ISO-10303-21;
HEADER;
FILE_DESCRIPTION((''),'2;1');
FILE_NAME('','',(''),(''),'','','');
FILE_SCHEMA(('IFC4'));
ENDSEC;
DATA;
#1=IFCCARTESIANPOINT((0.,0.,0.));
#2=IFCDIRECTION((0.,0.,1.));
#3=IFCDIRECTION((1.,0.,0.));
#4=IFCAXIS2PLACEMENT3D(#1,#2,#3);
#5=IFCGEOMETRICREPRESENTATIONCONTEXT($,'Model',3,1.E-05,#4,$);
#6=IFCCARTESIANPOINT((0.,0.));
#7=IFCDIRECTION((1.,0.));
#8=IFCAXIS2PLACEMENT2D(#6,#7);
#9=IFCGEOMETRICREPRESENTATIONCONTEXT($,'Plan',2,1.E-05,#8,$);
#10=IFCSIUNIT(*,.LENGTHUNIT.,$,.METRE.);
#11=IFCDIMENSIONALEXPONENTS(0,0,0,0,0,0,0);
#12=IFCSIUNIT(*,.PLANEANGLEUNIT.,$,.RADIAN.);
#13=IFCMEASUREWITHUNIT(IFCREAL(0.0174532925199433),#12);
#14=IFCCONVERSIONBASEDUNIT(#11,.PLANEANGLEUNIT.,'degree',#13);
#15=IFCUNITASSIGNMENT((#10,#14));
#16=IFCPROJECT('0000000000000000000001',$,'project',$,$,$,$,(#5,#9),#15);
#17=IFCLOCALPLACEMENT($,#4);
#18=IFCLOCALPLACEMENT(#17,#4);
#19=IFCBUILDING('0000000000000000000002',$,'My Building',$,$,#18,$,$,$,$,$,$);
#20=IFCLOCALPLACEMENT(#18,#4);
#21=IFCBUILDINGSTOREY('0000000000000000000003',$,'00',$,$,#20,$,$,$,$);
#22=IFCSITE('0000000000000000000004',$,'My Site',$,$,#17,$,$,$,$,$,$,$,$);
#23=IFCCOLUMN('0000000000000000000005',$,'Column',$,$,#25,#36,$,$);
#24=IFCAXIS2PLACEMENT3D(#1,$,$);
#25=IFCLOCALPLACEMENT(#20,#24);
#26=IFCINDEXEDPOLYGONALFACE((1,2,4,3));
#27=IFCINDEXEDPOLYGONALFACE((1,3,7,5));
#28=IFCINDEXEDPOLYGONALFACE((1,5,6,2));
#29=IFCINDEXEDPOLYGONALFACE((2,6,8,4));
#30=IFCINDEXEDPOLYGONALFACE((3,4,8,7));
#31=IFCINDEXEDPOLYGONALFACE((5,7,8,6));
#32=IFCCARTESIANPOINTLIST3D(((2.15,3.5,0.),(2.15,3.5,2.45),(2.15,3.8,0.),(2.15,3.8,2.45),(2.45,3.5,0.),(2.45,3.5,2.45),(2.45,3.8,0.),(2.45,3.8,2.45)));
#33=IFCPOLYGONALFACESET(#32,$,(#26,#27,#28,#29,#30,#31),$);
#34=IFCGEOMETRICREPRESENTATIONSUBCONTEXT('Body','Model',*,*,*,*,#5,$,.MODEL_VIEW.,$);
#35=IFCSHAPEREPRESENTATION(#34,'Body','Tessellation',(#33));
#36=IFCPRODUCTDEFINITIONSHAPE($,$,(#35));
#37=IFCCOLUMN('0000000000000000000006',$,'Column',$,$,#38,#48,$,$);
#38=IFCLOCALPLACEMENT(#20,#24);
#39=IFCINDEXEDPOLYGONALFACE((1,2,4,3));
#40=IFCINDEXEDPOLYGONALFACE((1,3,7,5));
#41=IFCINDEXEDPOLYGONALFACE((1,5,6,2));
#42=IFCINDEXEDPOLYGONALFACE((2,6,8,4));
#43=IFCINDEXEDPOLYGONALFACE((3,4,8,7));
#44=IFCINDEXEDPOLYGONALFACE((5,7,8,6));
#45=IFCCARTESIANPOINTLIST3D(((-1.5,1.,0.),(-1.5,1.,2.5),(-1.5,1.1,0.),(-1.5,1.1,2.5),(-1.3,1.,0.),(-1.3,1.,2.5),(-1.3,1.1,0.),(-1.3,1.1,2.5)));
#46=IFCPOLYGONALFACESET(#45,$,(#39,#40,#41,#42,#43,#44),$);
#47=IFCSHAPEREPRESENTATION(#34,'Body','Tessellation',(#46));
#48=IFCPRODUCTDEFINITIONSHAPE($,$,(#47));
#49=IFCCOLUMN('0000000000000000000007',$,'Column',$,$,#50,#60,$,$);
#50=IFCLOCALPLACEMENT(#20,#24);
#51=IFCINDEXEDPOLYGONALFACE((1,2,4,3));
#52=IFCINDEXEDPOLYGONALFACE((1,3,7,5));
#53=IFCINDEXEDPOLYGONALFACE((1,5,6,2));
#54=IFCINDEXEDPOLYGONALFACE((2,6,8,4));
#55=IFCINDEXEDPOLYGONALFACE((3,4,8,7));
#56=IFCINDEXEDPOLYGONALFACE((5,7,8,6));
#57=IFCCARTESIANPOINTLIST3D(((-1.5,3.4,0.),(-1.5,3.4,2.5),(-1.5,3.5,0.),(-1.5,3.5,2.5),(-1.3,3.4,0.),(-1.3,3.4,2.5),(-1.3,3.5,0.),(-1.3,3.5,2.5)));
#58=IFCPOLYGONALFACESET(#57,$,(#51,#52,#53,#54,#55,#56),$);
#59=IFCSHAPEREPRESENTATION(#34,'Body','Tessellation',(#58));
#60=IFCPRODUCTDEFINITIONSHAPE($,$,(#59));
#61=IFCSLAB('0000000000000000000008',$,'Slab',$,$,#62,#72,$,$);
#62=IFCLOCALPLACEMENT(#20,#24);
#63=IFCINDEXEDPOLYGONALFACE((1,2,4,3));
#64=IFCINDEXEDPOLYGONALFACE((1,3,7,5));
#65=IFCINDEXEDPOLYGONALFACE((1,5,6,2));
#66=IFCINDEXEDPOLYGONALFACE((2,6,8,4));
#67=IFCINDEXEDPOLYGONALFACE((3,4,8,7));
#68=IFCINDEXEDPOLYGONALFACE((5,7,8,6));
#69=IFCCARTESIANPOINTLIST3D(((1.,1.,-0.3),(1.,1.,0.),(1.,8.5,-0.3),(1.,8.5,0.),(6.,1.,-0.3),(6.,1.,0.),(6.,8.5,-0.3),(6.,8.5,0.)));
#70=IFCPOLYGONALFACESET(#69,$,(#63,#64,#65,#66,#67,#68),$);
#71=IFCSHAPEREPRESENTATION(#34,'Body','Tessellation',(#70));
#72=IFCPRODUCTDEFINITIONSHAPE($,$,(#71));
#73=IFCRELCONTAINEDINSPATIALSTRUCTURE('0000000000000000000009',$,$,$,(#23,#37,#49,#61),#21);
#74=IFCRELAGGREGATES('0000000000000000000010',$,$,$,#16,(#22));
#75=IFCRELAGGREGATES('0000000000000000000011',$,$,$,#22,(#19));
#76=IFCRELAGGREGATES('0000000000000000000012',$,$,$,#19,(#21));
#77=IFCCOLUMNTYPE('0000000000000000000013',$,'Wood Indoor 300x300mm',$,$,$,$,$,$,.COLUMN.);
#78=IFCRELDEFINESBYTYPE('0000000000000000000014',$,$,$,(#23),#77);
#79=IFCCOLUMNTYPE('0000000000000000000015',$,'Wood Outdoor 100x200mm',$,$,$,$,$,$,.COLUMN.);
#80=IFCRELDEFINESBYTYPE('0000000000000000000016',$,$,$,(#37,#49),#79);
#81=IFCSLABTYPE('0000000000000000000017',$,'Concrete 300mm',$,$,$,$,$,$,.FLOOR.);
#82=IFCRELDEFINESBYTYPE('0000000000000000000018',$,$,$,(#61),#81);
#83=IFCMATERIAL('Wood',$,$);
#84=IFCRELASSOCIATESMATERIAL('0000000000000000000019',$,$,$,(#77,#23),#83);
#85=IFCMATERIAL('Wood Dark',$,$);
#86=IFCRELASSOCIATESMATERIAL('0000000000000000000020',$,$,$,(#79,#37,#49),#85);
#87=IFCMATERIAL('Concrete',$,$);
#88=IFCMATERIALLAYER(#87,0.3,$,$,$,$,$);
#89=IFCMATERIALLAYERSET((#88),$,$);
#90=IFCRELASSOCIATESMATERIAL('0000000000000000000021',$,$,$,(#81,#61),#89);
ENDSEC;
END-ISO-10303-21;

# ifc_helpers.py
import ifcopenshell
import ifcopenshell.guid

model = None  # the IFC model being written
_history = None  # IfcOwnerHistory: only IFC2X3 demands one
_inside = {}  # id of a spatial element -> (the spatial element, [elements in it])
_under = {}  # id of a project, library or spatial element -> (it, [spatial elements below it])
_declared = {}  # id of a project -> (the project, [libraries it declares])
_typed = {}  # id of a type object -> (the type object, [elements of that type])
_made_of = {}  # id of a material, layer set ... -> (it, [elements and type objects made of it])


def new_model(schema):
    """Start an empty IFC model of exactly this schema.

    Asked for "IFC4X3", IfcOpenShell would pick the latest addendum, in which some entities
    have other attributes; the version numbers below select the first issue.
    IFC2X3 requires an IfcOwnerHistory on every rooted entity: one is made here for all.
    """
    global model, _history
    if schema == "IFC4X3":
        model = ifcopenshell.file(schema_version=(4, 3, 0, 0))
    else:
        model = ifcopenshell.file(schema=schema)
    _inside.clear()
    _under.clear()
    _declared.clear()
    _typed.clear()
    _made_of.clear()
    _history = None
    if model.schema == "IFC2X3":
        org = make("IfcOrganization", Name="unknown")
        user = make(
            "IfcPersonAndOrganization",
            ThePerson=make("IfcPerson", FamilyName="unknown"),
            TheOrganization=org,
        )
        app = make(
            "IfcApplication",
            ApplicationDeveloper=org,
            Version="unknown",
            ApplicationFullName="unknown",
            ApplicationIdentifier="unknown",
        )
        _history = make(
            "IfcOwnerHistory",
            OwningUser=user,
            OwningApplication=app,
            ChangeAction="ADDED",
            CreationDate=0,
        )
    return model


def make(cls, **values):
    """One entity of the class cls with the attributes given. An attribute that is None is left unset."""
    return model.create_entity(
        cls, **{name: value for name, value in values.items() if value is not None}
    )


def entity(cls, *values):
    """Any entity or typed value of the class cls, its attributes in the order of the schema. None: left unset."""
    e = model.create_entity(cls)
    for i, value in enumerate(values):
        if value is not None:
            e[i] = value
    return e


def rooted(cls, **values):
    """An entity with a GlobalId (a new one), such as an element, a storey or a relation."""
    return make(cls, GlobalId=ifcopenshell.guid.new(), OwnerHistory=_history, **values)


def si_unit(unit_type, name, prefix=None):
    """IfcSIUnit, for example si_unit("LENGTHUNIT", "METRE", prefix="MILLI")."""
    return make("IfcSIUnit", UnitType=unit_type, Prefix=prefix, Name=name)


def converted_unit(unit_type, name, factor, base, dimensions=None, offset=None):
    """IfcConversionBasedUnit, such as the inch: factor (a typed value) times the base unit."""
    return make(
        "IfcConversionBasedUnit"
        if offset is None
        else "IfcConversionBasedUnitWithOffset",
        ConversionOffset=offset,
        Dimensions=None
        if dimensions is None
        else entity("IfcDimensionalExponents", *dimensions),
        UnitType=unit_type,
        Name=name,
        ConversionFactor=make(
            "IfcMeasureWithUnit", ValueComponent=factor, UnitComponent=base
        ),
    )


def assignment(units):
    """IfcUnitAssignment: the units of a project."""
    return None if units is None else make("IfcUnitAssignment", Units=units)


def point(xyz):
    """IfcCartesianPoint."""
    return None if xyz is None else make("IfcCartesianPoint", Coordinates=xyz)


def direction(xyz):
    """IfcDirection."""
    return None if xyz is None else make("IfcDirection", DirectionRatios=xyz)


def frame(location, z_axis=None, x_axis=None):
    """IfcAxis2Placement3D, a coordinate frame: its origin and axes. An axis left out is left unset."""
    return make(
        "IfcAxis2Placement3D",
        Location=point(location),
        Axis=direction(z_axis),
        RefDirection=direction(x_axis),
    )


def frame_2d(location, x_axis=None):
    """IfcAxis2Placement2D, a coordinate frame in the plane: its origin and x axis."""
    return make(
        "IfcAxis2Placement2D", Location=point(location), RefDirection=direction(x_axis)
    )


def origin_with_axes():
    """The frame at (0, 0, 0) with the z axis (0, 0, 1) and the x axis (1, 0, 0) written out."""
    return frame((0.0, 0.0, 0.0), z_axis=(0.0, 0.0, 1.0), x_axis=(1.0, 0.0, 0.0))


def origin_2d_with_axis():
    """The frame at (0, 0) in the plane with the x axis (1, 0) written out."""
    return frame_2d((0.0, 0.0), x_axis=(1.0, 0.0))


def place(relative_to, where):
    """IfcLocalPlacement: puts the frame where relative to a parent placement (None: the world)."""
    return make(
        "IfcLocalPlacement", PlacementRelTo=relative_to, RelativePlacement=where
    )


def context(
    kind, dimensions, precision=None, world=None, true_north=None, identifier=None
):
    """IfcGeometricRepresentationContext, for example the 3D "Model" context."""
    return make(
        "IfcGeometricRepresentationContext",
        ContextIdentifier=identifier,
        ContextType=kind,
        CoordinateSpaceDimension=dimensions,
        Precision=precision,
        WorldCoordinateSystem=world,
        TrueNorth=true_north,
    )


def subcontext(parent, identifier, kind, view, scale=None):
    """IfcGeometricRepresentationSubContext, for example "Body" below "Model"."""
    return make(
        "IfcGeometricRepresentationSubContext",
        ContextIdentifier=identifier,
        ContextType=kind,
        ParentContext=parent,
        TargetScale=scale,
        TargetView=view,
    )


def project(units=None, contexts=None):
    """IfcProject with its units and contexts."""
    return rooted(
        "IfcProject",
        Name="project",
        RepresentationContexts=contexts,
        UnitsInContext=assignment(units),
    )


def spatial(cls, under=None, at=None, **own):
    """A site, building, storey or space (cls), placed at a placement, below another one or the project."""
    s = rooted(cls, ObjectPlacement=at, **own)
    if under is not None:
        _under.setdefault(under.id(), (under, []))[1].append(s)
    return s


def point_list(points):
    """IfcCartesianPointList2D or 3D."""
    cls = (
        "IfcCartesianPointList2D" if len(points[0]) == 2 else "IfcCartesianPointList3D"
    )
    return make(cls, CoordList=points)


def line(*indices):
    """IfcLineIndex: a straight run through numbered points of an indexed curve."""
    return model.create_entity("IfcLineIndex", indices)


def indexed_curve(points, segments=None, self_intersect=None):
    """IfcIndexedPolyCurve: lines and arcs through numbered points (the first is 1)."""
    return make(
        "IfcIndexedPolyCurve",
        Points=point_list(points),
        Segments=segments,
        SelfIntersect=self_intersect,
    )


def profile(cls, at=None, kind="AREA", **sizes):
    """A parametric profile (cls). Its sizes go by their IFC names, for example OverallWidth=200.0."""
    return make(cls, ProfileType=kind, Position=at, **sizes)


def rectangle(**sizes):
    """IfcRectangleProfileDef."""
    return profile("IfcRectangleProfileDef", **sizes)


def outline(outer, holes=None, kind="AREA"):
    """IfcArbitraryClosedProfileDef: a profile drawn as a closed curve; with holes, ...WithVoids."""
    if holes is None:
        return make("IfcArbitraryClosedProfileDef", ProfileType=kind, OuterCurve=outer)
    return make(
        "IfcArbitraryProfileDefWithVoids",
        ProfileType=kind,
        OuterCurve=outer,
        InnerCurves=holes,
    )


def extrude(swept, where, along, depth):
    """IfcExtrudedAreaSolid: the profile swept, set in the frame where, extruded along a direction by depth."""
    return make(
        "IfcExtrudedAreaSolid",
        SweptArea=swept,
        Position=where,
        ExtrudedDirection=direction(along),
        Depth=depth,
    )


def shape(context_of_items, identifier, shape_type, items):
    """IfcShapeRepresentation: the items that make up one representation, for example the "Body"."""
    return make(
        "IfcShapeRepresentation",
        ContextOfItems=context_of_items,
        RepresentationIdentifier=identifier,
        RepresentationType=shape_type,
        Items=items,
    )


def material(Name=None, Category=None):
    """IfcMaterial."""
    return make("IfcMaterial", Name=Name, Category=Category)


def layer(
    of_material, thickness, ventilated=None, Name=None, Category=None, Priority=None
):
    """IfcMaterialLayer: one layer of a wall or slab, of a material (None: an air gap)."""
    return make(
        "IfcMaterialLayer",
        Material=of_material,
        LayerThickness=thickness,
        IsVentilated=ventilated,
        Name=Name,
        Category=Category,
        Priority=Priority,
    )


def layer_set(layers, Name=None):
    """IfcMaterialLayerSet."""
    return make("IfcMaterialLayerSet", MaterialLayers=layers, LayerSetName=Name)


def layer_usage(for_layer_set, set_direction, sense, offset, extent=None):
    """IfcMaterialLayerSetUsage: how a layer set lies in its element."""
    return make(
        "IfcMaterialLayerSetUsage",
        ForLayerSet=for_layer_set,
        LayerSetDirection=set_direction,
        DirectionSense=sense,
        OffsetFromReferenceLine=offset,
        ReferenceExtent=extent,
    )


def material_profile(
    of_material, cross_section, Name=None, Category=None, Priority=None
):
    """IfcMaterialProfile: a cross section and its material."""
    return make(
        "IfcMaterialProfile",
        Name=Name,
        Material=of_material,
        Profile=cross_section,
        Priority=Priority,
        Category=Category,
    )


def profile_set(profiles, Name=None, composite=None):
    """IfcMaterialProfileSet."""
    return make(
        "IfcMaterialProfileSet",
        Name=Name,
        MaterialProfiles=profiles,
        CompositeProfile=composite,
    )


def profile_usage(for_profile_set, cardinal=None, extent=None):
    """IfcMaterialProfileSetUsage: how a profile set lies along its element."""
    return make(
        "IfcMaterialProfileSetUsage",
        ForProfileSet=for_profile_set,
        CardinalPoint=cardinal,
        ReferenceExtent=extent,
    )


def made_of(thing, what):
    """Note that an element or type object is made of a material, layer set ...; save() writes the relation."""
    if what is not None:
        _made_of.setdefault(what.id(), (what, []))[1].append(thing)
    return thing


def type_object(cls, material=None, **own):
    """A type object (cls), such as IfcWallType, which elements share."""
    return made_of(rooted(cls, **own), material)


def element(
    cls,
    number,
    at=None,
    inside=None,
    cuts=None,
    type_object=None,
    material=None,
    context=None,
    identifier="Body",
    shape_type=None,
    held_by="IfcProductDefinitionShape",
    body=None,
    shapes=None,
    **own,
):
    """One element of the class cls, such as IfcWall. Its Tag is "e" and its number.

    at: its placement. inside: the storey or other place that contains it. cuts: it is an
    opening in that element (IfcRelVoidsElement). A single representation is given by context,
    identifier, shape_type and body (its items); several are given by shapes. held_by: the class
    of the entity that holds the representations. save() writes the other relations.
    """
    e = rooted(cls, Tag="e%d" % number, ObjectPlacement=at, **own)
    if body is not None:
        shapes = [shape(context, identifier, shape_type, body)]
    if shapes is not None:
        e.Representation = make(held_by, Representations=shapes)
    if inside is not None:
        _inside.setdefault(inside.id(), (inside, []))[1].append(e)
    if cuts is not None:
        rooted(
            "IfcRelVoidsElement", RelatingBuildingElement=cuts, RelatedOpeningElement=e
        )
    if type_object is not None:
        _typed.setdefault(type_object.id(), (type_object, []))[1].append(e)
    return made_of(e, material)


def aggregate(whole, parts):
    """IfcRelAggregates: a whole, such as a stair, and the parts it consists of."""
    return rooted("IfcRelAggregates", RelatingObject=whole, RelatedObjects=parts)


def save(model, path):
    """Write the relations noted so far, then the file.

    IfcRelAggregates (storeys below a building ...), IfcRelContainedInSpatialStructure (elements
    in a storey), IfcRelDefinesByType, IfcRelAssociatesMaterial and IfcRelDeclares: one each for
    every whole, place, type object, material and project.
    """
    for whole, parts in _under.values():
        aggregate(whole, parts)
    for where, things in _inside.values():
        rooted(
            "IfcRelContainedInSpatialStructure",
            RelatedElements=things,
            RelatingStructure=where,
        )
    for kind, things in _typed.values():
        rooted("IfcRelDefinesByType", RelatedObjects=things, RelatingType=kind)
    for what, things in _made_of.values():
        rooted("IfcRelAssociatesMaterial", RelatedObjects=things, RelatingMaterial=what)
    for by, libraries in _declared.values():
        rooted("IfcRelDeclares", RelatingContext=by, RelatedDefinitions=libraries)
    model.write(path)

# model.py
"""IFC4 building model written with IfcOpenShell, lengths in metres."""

from ifc_helpers import new_model, entity, si_unit, converted_unit, frame, origin_with_axes, origin_2d_with_axis, place, context, subcontext, project, spatial, line, indexed_curve, rectangle, outline, extrude, material, layer, layer_set, layer_usage, material_profile, profile_set, profile_usage, type_object, element, save


model = new_model("IFC4")

# Units and contexts
model_context = context("Model", 3, precision=1e-05, world=origin_with_axes())
plan_context = context("Plan", 2, precision=1e-05, world=origin_2d_with_axis())
body_context_1 = subcontext(model_context, "Body", "Model", "MODEL_VIEW")
ifc_project = project(units=[si_unit("LENGTHUNIT", "METRE"), converted_unit("PLANEANGLEUNIT", "degree", entity("IfcReal", 0.0174532925199433), si_unit("PLANEANGLEUNIT", "RADIAN"), dimensions=[0, 0, 0, 0, 0, 0, 0])], contexts=[model_context, plan_context])

# Site, building, storey
site_placement = place(None, origin_with_axes())
site = spatial("IfcSite", under=ifc_project, at=site_placement, Name="My Site")
building_placement = place(site_placement, origin_with_axes())
building = spatial("IfcBuilding", under=site, at=building_placement, Name="My Building")
storey_placement = place(building_placement, origin_with_axes())
storey = spatial("IfcBuildingStorey", under=building, at=storey_placement, Name="00")

# Columns
ifc_material_1 = material(Name="Wood")
ifc_material_profile_1 = material_profile(ifc_material_1, rectangle(XDim=0.3, YDim=0.3))
ifc_profile_set_1 = profile_set([ifc_material_profile_1])
ifc_profile_usage_1 = profile_usage(ifc_profile_set_1, cardinal=3)
column_type_1 = type_object("IfcColumnType", Name="Wood Indoor 300x300mm", PredefinedType="COLUMN", material=ifc_profile_set_1)
column_1_placement = place(storey_placement, frame((2.15, 3.5, 0.0), z_axis=(0.0, 0.0, 1.0), x_axis=(1.0, 0.0, 0.0)))
element("IfcColumn", 1, at=column_1_placement, inside=storey, type_object=column_type_1, material=ifc_profile_usage_1, Name="Column", context=body_context_1, shape_type="SweptSolid", body=[
    extrude(rectangle(XDim=0.3, YDim=0.3), frame((0.15, 0.15, 0.0), z_axis=(0.0, 0.0, 1.0), x_axis=(1.0, 0.0, 0.0)), (0.0, 0.0, 1.0), 2.45),
])
ifc_material_2 = material(Name="Wood Dark")
ifc_material_profile_2 = material_profile(ifc_material_2, rectangle(XDim=0.1, YDim=0.2, kind="CURVE"))
ifc_profile_set_2 = profile_set([ifc_material_profile_2])
ifc_profile_usage_2 = profile_usage(ifc_profile_set_2, cardinal=1)
column_type_2 = type_object("IfcColumnType", Name="Wood Outdoor 100x200mm", PredefinedType="COLUMN", material=ifc_profile_set_2)
column_2_placement = place(storey_placement, frame((-1.5, 1.0, 0.0), z_axis=(0.0, 0.0, 1.0), x_axis=(0.0, -1.0, 0.0)))
element("IfcColumn", 2, at=column_2_placement, inside=storey, type_object=column_type_2, material=ifc_profile_usage_2, Name="Column", context=body_context_1, shape_type="SweptSolid", body=[
    extrude(rectangle(XDim=0.1, YDim=0.2, kind="CURVE"), frame((-0.05, 0.1, 0.0), z_axis=(0.0, 0.0, 1.0), x_axis=(1.0, 0.0, 0.0)), (0.0, 0.0, 1.0), 2.5),
])
ifc_profile_usage_3 = profile_usage(ifc_profile_set_2, cardinal=3)
column_3_placement = place(storey_placement, frame((-1.5, 3.5, 0.0), z_axis=(0.0, 0.0, 1.0), x_axis=(0.0, -1.0, 0.0)))
element("IfcColumn", 3, at=column_3_placement, inside=storey, type_object=column_type_2, material=ifc_profile_usage_3, Name="Column", context=body_context_1, shape_type="SweptSolid", body=[
    extrude(rectangle(XDim=0.1, YDim=0.2, kind="CURVE"), frame((0.05, 0.1, 0.0), z_axis=(0.0, 0.0, 1.0), x_axis=(1.0, 0.0, 0.0)), (0.0, 0.0, 1.0), 2.5),
])

# Slab
ifc_material_3 = material(Name="Concrete")
ifc_layer_1 = layer(ifc_material_3, 0.3)
ifc_layer_set_1 = layer_set([ifc_layer_1])
ifc_layer_usage_1 = layer_usage(ifc_layer_set_1, "AXIS3", "POSITIVE", 0.0)
slab_type = type_object("IfcSlabType", Name="Concrete 300mm", PredefinedType="FLOOR", material=ifc_layer_set_1)
slab_placement = place(storey_placement, frame((1.0, 1.0, -0.3), z_axis=(0.0, 0.0, 1.0), x_axis=(1.0, 0.0, 0.0)))
element("IfcSlab", 4, at=slab_placement, inside=storey, type_object=slab_type, material=ifc_layer_usage_1, Name="Slab", context=body_context_1, shape_type="SweptSolid", body=[
    extrude(outline(indexed_curve([(0.0, 0.0), (5.0, 0.0), (5.0, 7.5), (0.0, 7.5)], segments=[line(3, 2), line(2, 1), line(1, 4), line(4, 3)], self_intersect=False)), None, (0.0, 0.0, 1.0), 0.3),
])

save(model, "model.ifc")
